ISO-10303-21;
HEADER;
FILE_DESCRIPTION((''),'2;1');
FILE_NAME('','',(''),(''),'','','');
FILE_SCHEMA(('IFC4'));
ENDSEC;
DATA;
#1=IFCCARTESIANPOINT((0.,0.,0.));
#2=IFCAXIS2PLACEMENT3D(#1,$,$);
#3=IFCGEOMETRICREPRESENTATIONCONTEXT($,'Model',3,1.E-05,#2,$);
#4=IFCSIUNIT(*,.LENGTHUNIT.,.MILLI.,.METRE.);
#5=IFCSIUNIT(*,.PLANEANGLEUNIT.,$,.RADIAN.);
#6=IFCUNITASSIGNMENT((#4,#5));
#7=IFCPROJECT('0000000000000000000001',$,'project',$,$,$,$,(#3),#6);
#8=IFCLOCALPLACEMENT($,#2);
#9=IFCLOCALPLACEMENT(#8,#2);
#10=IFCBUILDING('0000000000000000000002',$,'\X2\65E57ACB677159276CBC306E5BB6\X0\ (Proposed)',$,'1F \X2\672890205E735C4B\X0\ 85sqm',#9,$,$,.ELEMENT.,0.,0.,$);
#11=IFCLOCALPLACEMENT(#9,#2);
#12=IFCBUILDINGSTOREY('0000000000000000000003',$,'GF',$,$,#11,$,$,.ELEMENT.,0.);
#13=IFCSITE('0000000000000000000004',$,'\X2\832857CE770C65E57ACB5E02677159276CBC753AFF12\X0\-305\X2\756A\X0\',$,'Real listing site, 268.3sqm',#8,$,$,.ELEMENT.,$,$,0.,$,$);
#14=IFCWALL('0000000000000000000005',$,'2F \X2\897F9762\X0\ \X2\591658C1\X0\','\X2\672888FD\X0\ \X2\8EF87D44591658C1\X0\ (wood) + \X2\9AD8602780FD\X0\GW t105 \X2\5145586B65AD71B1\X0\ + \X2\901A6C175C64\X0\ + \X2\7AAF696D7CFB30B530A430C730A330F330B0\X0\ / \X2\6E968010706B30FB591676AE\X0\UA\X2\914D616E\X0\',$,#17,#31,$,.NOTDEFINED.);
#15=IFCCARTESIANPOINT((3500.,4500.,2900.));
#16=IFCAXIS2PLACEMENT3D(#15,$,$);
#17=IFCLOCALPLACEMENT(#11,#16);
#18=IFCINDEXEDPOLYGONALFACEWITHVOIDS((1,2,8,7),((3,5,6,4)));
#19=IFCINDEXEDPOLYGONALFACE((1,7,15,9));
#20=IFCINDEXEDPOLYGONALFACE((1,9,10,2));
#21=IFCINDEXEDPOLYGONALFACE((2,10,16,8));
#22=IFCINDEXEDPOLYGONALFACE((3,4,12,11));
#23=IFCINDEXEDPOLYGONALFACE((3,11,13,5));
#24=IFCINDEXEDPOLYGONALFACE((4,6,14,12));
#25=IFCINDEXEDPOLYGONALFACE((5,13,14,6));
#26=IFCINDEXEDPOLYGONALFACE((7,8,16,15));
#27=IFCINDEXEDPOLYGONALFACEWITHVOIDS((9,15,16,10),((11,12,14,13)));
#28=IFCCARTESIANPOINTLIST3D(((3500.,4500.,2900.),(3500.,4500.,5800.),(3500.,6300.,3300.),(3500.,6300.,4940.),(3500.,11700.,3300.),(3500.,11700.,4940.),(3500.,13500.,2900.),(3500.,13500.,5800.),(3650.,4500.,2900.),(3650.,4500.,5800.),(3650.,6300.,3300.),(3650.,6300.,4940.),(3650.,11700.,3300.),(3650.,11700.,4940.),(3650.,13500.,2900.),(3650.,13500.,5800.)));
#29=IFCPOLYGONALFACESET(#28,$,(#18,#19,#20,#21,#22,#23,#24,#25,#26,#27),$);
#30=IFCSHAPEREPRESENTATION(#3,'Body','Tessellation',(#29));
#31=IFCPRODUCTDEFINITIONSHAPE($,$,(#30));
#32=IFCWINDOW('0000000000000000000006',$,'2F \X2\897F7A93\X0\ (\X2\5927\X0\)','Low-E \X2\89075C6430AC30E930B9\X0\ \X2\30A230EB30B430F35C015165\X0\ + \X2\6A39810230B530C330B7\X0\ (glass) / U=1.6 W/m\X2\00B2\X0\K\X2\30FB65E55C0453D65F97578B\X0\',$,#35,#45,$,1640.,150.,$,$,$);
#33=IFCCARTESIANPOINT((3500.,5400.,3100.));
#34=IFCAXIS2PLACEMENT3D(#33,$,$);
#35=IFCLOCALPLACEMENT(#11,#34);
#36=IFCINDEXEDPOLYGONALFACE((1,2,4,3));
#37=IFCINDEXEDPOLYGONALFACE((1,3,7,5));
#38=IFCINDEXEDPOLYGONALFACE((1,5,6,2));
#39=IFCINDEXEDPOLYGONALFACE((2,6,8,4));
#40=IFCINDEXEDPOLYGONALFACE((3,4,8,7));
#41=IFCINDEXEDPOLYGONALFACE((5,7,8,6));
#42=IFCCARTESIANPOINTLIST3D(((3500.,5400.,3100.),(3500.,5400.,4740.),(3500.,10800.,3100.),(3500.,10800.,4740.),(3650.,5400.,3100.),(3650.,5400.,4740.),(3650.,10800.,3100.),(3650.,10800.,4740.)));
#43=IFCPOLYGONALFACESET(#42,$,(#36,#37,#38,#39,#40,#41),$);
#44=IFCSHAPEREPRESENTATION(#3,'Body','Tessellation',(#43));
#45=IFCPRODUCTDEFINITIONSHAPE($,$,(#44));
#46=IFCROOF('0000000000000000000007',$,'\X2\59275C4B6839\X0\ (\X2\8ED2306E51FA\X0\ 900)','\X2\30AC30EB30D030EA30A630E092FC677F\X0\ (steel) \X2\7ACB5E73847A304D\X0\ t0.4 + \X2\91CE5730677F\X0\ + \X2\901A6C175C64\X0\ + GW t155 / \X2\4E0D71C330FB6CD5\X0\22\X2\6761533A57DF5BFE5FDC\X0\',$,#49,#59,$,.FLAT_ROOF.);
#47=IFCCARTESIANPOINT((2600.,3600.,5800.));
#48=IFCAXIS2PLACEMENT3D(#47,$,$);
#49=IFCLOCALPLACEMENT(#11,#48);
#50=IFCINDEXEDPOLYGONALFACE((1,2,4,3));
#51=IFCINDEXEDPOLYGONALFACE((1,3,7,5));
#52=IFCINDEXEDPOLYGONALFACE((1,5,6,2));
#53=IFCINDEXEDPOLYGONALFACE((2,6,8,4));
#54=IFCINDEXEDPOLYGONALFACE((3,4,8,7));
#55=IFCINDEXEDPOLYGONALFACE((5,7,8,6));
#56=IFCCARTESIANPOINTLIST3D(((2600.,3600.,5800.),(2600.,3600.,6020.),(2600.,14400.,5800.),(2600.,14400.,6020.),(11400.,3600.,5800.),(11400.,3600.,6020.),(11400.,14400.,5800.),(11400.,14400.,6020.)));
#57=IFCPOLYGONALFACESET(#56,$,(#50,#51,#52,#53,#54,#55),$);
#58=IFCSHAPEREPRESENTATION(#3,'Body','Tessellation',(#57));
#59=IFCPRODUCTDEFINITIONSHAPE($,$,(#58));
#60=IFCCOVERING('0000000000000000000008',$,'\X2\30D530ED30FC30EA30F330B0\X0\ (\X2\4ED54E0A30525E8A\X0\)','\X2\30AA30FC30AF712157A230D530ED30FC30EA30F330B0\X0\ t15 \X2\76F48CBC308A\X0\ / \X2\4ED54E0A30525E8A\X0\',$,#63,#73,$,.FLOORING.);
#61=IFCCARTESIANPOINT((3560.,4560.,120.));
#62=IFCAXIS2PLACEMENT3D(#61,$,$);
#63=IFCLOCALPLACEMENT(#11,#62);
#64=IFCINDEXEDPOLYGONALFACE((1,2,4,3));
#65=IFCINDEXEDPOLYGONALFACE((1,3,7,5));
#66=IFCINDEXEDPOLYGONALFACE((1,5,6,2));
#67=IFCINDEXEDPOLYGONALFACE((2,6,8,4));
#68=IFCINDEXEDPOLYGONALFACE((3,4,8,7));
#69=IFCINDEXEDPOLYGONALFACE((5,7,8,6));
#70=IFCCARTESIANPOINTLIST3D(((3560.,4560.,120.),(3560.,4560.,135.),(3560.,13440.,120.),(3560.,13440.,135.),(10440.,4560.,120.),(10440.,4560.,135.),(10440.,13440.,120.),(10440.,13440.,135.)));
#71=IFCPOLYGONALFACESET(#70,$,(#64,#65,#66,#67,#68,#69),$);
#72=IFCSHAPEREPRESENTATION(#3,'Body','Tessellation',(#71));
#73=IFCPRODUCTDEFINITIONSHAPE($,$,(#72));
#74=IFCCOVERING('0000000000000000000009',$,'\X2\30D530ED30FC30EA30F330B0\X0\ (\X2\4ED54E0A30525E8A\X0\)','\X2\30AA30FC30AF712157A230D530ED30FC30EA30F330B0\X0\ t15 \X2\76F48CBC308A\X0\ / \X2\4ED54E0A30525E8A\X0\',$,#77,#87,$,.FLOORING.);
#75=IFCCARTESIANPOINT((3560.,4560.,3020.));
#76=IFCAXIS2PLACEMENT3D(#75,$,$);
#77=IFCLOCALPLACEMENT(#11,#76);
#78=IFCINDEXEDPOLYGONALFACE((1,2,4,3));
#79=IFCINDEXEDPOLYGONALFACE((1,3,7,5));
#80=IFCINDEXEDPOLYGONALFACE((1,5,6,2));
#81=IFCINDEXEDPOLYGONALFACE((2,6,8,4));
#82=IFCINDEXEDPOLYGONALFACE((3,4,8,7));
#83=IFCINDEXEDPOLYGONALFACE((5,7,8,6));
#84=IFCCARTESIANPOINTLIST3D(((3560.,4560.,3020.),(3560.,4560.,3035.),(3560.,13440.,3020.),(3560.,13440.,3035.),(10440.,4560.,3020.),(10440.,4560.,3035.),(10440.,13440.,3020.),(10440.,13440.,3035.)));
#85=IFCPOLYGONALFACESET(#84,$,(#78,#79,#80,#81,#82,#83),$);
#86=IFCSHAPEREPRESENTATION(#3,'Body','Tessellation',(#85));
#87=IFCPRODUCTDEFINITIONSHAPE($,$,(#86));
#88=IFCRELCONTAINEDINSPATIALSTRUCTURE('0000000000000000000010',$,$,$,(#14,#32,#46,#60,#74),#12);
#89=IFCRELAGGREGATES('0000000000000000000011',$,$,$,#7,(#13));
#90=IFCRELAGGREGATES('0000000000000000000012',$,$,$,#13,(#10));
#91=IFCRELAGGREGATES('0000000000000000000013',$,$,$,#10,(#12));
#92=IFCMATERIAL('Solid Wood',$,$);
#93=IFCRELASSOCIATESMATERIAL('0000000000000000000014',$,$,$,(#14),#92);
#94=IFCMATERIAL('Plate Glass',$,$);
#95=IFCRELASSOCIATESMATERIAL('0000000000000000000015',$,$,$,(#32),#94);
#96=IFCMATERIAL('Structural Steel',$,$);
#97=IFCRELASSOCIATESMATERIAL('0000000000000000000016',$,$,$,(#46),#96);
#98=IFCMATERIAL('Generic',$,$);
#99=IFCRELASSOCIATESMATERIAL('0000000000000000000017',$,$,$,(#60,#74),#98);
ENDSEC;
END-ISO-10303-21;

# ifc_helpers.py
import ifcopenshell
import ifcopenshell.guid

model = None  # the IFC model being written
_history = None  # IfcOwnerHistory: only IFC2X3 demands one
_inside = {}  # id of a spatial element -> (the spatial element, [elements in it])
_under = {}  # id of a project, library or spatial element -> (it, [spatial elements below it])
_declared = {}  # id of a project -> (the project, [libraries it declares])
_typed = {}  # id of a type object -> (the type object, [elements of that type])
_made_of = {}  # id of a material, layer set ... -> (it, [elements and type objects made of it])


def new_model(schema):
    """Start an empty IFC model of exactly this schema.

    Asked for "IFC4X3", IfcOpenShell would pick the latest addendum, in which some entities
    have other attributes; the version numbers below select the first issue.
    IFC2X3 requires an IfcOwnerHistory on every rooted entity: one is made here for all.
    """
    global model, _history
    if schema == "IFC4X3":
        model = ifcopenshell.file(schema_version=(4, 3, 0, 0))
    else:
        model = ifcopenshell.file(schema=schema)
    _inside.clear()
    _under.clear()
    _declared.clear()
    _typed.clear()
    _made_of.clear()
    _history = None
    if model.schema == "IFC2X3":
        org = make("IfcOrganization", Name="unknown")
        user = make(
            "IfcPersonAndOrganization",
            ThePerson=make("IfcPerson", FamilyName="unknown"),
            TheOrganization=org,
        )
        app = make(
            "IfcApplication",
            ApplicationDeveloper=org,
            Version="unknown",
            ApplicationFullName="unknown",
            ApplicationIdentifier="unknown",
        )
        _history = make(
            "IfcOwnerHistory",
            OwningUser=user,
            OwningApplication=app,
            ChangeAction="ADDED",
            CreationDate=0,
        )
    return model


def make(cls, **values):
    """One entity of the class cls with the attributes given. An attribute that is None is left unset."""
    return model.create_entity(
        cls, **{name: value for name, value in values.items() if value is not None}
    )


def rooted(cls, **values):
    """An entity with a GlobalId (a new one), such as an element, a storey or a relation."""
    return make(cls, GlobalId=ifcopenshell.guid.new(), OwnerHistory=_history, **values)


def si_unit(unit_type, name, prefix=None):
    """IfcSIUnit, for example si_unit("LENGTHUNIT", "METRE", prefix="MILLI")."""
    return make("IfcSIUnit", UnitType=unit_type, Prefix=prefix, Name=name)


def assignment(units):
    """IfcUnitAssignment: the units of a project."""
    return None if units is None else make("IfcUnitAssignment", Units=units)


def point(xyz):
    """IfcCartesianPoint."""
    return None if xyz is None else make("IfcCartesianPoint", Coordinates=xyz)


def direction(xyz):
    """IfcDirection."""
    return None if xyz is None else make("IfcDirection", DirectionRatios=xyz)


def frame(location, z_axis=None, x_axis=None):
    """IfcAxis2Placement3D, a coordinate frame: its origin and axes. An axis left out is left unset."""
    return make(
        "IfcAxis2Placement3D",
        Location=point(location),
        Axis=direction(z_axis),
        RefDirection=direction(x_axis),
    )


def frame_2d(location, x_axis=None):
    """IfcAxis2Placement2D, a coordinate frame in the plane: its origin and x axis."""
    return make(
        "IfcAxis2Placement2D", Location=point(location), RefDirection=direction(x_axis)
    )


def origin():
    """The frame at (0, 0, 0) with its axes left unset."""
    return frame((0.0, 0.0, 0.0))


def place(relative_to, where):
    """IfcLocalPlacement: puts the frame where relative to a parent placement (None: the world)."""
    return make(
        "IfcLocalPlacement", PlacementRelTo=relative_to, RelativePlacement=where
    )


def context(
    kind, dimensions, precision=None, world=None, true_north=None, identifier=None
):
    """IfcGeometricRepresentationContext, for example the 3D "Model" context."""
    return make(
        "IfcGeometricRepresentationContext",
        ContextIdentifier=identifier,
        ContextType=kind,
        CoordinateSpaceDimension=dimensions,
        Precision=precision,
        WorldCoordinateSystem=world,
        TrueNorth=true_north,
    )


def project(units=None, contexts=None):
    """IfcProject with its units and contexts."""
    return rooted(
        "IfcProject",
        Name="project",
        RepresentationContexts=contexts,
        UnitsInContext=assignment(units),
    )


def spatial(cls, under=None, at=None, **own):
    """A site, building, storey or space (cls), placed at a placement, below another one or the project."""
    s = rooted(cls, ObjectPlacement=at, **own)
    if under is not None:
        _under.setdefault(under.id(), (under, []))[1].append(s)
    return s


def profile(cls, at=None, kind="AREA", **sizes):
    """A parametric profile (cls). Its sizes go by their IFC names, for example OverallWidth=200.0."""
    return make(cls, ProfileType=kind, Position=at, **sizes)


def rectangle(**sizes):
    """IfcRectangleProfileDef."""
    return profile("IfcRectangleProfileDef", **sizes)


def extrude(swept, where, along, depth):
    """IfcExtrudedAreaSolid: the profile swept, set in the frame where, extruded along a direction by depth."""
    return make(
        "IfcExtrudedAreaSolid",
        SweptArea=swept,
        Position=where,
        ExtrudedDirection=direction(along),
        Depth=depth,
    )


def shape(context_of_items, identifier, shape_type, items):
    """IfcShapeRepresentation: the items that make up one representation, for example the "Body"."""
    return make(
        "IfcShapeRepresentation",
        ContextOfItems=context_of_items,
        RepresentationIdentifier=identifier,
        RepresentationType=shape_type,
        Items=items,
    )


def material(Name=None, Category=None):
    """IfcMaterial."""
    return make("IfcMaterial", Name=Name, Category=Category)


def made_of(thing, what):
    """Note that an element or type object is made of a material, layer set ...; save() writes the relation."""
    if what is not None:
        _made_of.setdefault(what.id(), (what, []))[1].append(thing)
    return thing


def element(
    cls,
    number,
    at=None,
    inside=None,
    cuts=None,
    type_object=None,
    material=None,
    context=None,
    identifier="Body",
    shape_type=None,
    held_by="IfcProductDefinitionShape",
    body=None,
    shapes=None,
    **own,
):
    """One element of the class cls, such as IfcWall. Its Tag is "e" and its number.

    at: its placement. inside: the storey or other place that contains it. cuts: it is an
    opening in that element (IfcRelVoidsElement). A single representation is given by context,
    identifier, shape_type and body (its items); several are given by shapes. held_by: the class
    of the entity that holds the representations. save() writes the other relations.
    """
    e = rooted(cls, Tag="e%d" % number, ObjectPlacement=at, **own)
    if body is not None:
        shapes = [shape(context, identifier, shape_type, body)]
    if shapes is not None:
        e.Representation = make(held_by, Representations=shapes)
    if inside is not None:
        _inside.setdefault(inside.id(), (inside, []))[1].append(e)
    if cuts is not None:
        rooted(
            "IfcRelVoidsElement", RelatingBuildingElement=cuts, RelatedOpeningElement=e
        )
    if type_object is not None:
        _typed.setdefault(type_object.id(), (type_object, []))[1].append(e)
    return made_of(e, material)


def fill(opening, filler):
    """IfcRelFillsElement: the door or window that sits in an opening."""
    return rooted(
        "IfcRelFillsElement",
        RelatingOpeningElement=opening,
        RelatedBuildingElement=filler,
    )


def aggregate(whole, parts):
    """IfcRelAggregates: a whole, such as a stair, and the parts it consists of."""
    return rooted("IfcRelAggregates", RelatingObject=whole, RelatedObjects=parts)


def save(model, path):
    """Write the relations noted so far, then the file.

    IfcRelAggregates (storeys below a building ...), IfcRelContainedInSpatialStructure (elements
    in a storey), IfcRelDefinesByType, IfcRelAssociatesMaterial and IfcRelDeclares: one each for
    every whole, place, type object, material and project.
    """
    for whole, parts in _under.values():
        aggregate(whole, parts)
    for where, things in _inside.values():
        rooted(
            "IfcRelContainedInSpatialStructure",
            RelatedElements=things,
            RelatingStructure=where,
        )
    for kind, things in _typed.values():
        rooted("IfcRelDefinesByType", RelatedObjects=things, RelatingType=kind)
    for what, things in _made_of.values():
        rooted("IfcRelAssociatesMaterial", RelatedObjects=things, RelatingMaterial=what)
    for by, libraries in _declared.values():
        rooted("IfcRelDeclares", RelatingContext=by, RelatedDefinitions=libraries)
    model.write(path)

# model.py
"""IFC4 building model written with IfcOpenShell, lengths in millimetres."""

from ifc_helpers import new_model, si_unit, frame, frame_2d, origin, place, context, project, spatial, rectangle, extrude, material, element, fill, save


model = new_model("IFC4")

# Units and contexts
model_context = context("Model", 3, precision=1e-05, world=origin())
ifc_project = project(units=[si_unit("LENGTHUNIT", "METRE", prefix="MILLI"), si_unit("PLANEANGLEUNIT", "RADIAN")], contexts=[model_context])

# Site, building, storey
site_placement = place(None, origin())
site = spatial("IfcSite", under=ifc_project, at=site_placement, Name="茨城県日立市東大沼町２-305番", ObjectType="Real listing site, 268.3sqm", CompositionType="ELEMENT", RefElevation=0.0)
building_placement = place(site_placement, origin())
building = spatial("IfcBuilding", under=site, at=building_placement, Name="日立東大沼の家 (Proposed)", ObjectType="1F 木造平屋 85sqm", CompositionType="ELEMENT", ElevationOfRefHeight=0.0, ElevationOfTerrain=0.0)
storey_placement = place(building_placement, origin())
storey = spatial("IfcBuildingStorey", under=building, at=storey_placement, Name="GF", CompositionType="ELEMENT", Elevation=0.0)

# Shared definitions
ifc_material_1 = material(Name="Solid Wood")
ifc_material_2 = material(Name="Generic")

# Shared definitions
ifc_material_3 = material(Name="Plate Glass")

# Wall, opening, window
wall_1_placement = place(storey_placement, frame((3500.0, 4500.0, 2900.0)))
wall_1 = element("IfcWall", 1, at=wall_1_placement, inside=storey, material=ifc_material_1, Name="2F 西面 外壁", Description="木製 軸組外壁 (wood) + 高性能GW t105 充填断熱 + 通気層 + 窯業系サイディング / 準耐火・外皮UA配慮", PredefinedType="NOTDEFINED", context=model_context, shape_type="SweptSolid", body=[
    extrude(rectangle(XDim=150.0, YDim=9000.0, at=frame_2d((75.0, 4500.0))), frame((3500.0, 4500.0, 2900.0)), (0.0, 0.0, 1.0), 2900.0),
])
opening_1_placement = place(storey_placement, frame((3500.0, 5400.0, 3100.0)))
opening_1 = element("IfcOpeningElement", 2, at=opening_1_placement, cuts=wall_1, PredefinedType="NOTDEFINED", context=model_context, shape_type="SweptSolid", body=[
    extrude(rectangle(XDim=150.0, YDim=5400.0, at=frame_2d((75.0, 2700.0))), frame((3500.0, 5400.0, 3100.0)), (0.0, 0.0, 1.0), 1640.0),
])
window_1_placement = place(storey_placement, frame((3500.0, 5400.0, 3100.0)))
window_1 = element("IfcWindow", 3, at=window_1_placement, inside=storey, material=ifc_material_3, Name="2F 西窓 (大)", Description="Low-E 複層ガラス アルゴン封入 + 樹脂サッシ (glass) / U=1.6 W/m²K・日射取得型", OverallHeight=1640.0, OverallWidth=150.0, context=model_context, shape_type="SweptSolid", body=[
    extrude(rectangle(XDim=150.0, YDim=5400.0, at=frame_2d((75.0, 2700.0))), frame((3500.0, 5400.0, 3100.0)), (0.0, 0.0, 1.0), 1640.0),
])
fill(opening_1, window_1)

# Roof
ifc_material_4 = material(Name="Structural Steel")
roof_placement = place(storey_placement, frame((2600.0, 3600.0, 5800.0)))
element("IfcRoof", 4, at=roof_placement, inside=storey, material=ifc_material_4, Name="大屋根 (軒の出 900)", Description="ガルバリウム鋼板 (steel) 立平葺き t0.4 + 野地板 + 通気層 + GW t155 / 不燃・法22条区域対応", PredefinedType="FLAT_ROOF", context=model_context, shape_type="SweptSolid", body=[
    extrude(rectangle(XDim=8800.0, YDim=10800.0, at=frame_2d((4400.0, 5400.0))), frame((2600.0, 3600.0, 5800.0)), (0.0, 0.0, 1.0), 220.0),
])

# Coverings
covering_1_placement = place(storey_placement, frame((3560.0, 4560.0, 120.0)))
element("IfcCovering", 5, at=covering_1_placement, inside=storey, material=ifc_material_2, Name="フローリング (仕上げ床)", Description="オーク無垢フローリング t15 直貼り / 仕上げ床", PredefinedType="FLOORING", context=model_context, shape_type="SweptSolid", body=[
    extrude(rectangle(XDim=6880.0, YDim=8880.0, at=frame_2d((3440.0, 4440.0))), frame((3560.0, 4560.0, 120.0)), (0.0, 0.0, 1.0), 15.0),
])
covering_2_placement = place(storey_placement, frame((3560.0, 4560.0, 3020.0)))
element("IfcCovering", 6, at=covering_2_placement, inside=storey, material=ifc_material_2, Name="フローリング (仕上げ床)", Description="オーク無垢フローリング t15 直貼り / 仕上げ床", PredefinedType="FLOORING", context=model_context, shape_type="SweptSolid", body=[
    extrude(rectangle(XDim=6880.0, YDim=8880.0, at=frame_2d((3440.0, 4440.0))), frame((3560.0, 4560.0, 3020.0)), (0.0, 0.0, 1.0), 15.0),
])

save(model, "model.ifc")
